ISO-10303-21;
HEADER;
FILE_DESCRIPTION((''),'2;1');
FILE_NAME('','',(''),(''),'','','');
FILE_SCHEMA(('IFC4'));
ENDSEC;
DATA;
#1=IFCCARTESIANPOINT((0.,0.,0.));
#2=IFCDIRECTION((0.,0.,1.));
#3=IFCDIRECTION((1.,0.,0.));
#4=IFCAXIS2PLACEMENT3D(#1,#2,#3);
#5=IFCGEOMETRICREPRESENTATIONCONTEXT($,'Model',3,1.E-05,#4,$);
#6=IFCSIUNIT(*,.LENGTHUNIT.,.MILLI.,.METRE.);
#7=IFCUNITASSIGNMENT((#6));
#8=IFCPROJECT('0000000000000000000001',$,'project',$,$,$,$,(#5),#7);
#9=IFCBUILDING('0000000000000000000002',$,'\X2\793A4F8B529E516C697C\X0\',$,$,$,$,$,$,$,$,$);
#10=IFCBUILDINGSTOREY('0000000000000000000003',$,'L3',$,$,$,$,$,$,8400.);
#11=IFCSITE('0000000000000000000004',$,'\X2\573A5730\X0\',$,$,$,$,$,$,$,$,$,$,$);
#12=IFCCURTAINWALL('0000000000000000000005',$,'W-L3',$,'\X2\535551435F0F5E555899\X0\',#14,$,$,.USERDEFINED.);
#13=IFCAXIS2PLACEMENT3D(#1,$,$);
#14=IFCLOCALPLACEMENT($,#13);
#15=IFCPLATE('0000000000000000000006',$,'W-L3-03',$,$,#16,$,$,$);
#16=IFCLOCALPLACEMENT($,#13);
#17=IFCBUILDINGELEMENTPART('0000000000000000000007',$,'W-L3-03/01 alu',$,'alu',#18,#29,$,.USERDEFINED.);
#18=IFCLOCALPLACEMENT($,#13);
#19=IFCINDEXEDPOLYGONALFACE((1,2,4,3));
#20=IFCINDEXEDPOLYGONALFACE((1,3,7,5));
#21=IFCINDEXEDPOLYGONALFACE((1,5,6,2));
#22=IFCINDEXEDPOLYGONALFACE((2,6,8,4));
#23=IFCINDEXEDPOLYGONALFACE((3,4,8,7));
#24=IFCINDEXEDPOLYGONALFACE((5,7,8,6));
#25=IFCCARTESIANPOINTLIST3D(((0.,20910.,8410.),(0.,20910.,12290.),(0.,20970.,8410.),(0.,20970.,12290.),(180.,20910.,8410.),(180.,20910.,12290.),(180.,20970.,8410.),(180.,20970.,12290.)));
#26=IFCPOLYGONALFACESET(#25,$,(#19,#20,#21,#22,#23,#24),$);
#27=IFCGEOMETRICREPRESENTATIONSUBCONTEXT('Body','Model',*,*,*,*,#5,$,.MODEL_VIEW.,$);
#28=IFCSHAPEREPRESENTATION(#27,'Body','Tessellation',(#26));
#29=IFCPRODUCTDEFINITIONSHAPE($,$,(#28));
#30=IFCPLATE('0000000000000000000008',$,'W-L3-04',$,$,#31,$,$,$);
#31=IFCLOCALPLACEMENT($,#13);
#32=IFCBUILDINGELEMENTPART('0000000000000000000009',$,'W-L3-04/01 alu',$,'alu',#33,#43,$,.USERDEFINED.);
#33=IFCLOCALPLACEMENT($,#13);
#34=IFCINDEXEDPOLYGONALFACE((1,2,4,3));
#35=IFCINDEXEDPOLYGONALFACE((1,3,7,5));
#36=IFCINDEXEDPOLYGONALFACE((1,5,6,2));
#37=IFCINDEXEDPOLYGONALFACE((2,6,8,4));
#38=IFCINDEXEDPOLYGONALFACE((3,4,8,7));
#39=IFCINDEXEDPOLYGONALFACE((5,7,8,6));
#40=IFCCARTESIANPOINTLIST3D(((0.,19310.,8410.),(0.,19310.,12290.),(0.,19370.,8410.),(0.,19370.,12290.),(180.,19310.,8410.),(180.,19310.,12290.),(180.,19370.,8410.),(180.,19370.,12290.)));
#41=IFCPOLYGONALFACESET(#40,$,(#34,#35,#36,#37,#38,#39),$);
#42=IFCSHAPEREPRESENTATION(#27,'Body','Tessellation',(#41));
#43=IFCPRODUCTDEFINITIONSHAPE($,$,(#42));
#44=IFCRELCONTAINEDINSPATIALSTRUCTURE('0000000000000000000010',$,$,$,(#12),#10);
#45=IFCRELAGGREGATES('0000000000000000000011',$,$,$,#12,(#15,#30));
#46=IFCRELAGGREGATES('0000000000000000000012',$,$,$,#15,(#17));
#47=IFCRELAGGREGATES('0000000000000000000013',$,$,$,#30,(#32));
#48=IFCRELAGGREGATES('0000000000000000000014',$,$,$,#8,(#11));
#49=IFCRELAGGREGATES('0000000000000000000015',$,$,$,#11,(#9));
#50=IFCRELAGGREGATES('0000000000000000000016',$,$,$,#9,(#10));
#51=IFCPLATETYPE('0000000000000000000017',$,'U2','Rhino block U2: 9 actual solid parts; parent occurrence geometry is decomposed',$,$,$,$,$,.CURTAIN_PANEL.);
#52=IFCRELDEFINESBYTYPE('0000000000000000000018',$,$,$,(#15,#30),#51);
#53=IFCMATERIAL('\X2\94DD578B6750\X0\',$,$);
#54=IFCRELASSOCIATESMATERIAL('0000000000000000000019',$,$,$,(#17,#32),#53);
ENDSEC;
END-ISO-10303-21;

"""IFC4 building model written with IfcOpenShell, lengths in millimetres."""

from ifc_helpers import new_model, si_unit, frame, frame_2d, origin, origin_with_axes, place, context, subcontext, project, spatial, rectangle, extrude, source, transform, mapped, material, type_object, element, aggregate, save


model = new_model("IFC4")

# Units and contexts
model_context = context("Model", 3, precision=1e-05, world=origin_with_axes())
body_context = subcontext(model_context, "Body", "Model", "MODEL_VIEW")
ifc_project = project(units=[si_unit("LENGTHUNIT", "METRE", prefix="MILLI")], contexts=[model_context])

# Site, building, storey
site = spatial("IfcSite", under=ifc_project, Name="场地")
building = spatial("IfcBuilding", under=site, Name="示例办公楼")
storey = spatial("IfcBuildingStorey", under=building, Name="L3", Elevation=8400.0)

# Curtain wall, plates, building element parts
curtain_wall = element("IfcCurtainWall", 1, inside=storey, Name="W-L3", ObjectType="单元式幕墙", PredefinedType="USERDEFINED")
plate_type = type_object("IfcPlateType", Name="U2", Description="Rhino block U2: 9 actual solid parts; parent occurrence geometry is decomposed", PredefinedType="CURTAIN_PANEL")
plate_1_placement = place(None, frame((0.0, 20970.0, 8410.0), z_axis=(0.0, 0.0, 1.0), x_axis=(0.0, -1.0, 0.0)))
plate_1 = element("IfcPlate", 2, at=plate_1_placement, type_object=plate_type, Name="W-L3-03")
ifc_material_1 = material(Name="铝型材")
shared_shape_1 = source(origin(), body_context, "Body", "SweptSolid", [
    extrude(rectangle(XDim=60.0, YDim=180.0, at=frame_2d((30.0, 90.0))), origin(), (0.0, 0.0, 1.0), 3880.0),
])
building_element_part_1_placement = place(plate_1_placement, origin())
building_element_part_1 = element("IfcBuildingElementPart", 3, at=building_element_part_1_placement, material=ifc_material_1, Name="W-L3-03/01 alu", ObjectType="alu", PredefinedType="USERDEFINED", context=body_context, shape_type="MappedRepresentation", body=[
    mapped(shared_shape_1, transform((0.0, 0.0, 0.0))),
])
plate_2_placement = place(None, frame((0.0, 19370.0, 8410.0), z_axis=(0.0, 0.0, 1.0), x_axis=(0.0, -1.0, 0.0)))
plate_2 = element("IfcPlate", 4, at=plate_2_placement, type_object=plate_type, Name="W-L3-04")
building_element_part_2_placement = place(plate_2_placement, origin())
building_element_part_2 = element("IfcBuildingElementPart", 5, at=building_element_part_2_placement, material=ifc_material_1, Name="W-L3-04/01 alu", ObjectType="alu", PredefinedType="USERDEFINED", context=body_context, shape_type="MappedRepresentation", body=[
    mapped(shared_shape_1, transform((0.0, 0.0, 0.0))),
])
aggregate(curtain_wall, [plate_1, plate_2])
aggregate(plate_1, [building_element_part_1])
aggregate(plate_2, [building_element_part_2])

save(model, "model.ifc")
